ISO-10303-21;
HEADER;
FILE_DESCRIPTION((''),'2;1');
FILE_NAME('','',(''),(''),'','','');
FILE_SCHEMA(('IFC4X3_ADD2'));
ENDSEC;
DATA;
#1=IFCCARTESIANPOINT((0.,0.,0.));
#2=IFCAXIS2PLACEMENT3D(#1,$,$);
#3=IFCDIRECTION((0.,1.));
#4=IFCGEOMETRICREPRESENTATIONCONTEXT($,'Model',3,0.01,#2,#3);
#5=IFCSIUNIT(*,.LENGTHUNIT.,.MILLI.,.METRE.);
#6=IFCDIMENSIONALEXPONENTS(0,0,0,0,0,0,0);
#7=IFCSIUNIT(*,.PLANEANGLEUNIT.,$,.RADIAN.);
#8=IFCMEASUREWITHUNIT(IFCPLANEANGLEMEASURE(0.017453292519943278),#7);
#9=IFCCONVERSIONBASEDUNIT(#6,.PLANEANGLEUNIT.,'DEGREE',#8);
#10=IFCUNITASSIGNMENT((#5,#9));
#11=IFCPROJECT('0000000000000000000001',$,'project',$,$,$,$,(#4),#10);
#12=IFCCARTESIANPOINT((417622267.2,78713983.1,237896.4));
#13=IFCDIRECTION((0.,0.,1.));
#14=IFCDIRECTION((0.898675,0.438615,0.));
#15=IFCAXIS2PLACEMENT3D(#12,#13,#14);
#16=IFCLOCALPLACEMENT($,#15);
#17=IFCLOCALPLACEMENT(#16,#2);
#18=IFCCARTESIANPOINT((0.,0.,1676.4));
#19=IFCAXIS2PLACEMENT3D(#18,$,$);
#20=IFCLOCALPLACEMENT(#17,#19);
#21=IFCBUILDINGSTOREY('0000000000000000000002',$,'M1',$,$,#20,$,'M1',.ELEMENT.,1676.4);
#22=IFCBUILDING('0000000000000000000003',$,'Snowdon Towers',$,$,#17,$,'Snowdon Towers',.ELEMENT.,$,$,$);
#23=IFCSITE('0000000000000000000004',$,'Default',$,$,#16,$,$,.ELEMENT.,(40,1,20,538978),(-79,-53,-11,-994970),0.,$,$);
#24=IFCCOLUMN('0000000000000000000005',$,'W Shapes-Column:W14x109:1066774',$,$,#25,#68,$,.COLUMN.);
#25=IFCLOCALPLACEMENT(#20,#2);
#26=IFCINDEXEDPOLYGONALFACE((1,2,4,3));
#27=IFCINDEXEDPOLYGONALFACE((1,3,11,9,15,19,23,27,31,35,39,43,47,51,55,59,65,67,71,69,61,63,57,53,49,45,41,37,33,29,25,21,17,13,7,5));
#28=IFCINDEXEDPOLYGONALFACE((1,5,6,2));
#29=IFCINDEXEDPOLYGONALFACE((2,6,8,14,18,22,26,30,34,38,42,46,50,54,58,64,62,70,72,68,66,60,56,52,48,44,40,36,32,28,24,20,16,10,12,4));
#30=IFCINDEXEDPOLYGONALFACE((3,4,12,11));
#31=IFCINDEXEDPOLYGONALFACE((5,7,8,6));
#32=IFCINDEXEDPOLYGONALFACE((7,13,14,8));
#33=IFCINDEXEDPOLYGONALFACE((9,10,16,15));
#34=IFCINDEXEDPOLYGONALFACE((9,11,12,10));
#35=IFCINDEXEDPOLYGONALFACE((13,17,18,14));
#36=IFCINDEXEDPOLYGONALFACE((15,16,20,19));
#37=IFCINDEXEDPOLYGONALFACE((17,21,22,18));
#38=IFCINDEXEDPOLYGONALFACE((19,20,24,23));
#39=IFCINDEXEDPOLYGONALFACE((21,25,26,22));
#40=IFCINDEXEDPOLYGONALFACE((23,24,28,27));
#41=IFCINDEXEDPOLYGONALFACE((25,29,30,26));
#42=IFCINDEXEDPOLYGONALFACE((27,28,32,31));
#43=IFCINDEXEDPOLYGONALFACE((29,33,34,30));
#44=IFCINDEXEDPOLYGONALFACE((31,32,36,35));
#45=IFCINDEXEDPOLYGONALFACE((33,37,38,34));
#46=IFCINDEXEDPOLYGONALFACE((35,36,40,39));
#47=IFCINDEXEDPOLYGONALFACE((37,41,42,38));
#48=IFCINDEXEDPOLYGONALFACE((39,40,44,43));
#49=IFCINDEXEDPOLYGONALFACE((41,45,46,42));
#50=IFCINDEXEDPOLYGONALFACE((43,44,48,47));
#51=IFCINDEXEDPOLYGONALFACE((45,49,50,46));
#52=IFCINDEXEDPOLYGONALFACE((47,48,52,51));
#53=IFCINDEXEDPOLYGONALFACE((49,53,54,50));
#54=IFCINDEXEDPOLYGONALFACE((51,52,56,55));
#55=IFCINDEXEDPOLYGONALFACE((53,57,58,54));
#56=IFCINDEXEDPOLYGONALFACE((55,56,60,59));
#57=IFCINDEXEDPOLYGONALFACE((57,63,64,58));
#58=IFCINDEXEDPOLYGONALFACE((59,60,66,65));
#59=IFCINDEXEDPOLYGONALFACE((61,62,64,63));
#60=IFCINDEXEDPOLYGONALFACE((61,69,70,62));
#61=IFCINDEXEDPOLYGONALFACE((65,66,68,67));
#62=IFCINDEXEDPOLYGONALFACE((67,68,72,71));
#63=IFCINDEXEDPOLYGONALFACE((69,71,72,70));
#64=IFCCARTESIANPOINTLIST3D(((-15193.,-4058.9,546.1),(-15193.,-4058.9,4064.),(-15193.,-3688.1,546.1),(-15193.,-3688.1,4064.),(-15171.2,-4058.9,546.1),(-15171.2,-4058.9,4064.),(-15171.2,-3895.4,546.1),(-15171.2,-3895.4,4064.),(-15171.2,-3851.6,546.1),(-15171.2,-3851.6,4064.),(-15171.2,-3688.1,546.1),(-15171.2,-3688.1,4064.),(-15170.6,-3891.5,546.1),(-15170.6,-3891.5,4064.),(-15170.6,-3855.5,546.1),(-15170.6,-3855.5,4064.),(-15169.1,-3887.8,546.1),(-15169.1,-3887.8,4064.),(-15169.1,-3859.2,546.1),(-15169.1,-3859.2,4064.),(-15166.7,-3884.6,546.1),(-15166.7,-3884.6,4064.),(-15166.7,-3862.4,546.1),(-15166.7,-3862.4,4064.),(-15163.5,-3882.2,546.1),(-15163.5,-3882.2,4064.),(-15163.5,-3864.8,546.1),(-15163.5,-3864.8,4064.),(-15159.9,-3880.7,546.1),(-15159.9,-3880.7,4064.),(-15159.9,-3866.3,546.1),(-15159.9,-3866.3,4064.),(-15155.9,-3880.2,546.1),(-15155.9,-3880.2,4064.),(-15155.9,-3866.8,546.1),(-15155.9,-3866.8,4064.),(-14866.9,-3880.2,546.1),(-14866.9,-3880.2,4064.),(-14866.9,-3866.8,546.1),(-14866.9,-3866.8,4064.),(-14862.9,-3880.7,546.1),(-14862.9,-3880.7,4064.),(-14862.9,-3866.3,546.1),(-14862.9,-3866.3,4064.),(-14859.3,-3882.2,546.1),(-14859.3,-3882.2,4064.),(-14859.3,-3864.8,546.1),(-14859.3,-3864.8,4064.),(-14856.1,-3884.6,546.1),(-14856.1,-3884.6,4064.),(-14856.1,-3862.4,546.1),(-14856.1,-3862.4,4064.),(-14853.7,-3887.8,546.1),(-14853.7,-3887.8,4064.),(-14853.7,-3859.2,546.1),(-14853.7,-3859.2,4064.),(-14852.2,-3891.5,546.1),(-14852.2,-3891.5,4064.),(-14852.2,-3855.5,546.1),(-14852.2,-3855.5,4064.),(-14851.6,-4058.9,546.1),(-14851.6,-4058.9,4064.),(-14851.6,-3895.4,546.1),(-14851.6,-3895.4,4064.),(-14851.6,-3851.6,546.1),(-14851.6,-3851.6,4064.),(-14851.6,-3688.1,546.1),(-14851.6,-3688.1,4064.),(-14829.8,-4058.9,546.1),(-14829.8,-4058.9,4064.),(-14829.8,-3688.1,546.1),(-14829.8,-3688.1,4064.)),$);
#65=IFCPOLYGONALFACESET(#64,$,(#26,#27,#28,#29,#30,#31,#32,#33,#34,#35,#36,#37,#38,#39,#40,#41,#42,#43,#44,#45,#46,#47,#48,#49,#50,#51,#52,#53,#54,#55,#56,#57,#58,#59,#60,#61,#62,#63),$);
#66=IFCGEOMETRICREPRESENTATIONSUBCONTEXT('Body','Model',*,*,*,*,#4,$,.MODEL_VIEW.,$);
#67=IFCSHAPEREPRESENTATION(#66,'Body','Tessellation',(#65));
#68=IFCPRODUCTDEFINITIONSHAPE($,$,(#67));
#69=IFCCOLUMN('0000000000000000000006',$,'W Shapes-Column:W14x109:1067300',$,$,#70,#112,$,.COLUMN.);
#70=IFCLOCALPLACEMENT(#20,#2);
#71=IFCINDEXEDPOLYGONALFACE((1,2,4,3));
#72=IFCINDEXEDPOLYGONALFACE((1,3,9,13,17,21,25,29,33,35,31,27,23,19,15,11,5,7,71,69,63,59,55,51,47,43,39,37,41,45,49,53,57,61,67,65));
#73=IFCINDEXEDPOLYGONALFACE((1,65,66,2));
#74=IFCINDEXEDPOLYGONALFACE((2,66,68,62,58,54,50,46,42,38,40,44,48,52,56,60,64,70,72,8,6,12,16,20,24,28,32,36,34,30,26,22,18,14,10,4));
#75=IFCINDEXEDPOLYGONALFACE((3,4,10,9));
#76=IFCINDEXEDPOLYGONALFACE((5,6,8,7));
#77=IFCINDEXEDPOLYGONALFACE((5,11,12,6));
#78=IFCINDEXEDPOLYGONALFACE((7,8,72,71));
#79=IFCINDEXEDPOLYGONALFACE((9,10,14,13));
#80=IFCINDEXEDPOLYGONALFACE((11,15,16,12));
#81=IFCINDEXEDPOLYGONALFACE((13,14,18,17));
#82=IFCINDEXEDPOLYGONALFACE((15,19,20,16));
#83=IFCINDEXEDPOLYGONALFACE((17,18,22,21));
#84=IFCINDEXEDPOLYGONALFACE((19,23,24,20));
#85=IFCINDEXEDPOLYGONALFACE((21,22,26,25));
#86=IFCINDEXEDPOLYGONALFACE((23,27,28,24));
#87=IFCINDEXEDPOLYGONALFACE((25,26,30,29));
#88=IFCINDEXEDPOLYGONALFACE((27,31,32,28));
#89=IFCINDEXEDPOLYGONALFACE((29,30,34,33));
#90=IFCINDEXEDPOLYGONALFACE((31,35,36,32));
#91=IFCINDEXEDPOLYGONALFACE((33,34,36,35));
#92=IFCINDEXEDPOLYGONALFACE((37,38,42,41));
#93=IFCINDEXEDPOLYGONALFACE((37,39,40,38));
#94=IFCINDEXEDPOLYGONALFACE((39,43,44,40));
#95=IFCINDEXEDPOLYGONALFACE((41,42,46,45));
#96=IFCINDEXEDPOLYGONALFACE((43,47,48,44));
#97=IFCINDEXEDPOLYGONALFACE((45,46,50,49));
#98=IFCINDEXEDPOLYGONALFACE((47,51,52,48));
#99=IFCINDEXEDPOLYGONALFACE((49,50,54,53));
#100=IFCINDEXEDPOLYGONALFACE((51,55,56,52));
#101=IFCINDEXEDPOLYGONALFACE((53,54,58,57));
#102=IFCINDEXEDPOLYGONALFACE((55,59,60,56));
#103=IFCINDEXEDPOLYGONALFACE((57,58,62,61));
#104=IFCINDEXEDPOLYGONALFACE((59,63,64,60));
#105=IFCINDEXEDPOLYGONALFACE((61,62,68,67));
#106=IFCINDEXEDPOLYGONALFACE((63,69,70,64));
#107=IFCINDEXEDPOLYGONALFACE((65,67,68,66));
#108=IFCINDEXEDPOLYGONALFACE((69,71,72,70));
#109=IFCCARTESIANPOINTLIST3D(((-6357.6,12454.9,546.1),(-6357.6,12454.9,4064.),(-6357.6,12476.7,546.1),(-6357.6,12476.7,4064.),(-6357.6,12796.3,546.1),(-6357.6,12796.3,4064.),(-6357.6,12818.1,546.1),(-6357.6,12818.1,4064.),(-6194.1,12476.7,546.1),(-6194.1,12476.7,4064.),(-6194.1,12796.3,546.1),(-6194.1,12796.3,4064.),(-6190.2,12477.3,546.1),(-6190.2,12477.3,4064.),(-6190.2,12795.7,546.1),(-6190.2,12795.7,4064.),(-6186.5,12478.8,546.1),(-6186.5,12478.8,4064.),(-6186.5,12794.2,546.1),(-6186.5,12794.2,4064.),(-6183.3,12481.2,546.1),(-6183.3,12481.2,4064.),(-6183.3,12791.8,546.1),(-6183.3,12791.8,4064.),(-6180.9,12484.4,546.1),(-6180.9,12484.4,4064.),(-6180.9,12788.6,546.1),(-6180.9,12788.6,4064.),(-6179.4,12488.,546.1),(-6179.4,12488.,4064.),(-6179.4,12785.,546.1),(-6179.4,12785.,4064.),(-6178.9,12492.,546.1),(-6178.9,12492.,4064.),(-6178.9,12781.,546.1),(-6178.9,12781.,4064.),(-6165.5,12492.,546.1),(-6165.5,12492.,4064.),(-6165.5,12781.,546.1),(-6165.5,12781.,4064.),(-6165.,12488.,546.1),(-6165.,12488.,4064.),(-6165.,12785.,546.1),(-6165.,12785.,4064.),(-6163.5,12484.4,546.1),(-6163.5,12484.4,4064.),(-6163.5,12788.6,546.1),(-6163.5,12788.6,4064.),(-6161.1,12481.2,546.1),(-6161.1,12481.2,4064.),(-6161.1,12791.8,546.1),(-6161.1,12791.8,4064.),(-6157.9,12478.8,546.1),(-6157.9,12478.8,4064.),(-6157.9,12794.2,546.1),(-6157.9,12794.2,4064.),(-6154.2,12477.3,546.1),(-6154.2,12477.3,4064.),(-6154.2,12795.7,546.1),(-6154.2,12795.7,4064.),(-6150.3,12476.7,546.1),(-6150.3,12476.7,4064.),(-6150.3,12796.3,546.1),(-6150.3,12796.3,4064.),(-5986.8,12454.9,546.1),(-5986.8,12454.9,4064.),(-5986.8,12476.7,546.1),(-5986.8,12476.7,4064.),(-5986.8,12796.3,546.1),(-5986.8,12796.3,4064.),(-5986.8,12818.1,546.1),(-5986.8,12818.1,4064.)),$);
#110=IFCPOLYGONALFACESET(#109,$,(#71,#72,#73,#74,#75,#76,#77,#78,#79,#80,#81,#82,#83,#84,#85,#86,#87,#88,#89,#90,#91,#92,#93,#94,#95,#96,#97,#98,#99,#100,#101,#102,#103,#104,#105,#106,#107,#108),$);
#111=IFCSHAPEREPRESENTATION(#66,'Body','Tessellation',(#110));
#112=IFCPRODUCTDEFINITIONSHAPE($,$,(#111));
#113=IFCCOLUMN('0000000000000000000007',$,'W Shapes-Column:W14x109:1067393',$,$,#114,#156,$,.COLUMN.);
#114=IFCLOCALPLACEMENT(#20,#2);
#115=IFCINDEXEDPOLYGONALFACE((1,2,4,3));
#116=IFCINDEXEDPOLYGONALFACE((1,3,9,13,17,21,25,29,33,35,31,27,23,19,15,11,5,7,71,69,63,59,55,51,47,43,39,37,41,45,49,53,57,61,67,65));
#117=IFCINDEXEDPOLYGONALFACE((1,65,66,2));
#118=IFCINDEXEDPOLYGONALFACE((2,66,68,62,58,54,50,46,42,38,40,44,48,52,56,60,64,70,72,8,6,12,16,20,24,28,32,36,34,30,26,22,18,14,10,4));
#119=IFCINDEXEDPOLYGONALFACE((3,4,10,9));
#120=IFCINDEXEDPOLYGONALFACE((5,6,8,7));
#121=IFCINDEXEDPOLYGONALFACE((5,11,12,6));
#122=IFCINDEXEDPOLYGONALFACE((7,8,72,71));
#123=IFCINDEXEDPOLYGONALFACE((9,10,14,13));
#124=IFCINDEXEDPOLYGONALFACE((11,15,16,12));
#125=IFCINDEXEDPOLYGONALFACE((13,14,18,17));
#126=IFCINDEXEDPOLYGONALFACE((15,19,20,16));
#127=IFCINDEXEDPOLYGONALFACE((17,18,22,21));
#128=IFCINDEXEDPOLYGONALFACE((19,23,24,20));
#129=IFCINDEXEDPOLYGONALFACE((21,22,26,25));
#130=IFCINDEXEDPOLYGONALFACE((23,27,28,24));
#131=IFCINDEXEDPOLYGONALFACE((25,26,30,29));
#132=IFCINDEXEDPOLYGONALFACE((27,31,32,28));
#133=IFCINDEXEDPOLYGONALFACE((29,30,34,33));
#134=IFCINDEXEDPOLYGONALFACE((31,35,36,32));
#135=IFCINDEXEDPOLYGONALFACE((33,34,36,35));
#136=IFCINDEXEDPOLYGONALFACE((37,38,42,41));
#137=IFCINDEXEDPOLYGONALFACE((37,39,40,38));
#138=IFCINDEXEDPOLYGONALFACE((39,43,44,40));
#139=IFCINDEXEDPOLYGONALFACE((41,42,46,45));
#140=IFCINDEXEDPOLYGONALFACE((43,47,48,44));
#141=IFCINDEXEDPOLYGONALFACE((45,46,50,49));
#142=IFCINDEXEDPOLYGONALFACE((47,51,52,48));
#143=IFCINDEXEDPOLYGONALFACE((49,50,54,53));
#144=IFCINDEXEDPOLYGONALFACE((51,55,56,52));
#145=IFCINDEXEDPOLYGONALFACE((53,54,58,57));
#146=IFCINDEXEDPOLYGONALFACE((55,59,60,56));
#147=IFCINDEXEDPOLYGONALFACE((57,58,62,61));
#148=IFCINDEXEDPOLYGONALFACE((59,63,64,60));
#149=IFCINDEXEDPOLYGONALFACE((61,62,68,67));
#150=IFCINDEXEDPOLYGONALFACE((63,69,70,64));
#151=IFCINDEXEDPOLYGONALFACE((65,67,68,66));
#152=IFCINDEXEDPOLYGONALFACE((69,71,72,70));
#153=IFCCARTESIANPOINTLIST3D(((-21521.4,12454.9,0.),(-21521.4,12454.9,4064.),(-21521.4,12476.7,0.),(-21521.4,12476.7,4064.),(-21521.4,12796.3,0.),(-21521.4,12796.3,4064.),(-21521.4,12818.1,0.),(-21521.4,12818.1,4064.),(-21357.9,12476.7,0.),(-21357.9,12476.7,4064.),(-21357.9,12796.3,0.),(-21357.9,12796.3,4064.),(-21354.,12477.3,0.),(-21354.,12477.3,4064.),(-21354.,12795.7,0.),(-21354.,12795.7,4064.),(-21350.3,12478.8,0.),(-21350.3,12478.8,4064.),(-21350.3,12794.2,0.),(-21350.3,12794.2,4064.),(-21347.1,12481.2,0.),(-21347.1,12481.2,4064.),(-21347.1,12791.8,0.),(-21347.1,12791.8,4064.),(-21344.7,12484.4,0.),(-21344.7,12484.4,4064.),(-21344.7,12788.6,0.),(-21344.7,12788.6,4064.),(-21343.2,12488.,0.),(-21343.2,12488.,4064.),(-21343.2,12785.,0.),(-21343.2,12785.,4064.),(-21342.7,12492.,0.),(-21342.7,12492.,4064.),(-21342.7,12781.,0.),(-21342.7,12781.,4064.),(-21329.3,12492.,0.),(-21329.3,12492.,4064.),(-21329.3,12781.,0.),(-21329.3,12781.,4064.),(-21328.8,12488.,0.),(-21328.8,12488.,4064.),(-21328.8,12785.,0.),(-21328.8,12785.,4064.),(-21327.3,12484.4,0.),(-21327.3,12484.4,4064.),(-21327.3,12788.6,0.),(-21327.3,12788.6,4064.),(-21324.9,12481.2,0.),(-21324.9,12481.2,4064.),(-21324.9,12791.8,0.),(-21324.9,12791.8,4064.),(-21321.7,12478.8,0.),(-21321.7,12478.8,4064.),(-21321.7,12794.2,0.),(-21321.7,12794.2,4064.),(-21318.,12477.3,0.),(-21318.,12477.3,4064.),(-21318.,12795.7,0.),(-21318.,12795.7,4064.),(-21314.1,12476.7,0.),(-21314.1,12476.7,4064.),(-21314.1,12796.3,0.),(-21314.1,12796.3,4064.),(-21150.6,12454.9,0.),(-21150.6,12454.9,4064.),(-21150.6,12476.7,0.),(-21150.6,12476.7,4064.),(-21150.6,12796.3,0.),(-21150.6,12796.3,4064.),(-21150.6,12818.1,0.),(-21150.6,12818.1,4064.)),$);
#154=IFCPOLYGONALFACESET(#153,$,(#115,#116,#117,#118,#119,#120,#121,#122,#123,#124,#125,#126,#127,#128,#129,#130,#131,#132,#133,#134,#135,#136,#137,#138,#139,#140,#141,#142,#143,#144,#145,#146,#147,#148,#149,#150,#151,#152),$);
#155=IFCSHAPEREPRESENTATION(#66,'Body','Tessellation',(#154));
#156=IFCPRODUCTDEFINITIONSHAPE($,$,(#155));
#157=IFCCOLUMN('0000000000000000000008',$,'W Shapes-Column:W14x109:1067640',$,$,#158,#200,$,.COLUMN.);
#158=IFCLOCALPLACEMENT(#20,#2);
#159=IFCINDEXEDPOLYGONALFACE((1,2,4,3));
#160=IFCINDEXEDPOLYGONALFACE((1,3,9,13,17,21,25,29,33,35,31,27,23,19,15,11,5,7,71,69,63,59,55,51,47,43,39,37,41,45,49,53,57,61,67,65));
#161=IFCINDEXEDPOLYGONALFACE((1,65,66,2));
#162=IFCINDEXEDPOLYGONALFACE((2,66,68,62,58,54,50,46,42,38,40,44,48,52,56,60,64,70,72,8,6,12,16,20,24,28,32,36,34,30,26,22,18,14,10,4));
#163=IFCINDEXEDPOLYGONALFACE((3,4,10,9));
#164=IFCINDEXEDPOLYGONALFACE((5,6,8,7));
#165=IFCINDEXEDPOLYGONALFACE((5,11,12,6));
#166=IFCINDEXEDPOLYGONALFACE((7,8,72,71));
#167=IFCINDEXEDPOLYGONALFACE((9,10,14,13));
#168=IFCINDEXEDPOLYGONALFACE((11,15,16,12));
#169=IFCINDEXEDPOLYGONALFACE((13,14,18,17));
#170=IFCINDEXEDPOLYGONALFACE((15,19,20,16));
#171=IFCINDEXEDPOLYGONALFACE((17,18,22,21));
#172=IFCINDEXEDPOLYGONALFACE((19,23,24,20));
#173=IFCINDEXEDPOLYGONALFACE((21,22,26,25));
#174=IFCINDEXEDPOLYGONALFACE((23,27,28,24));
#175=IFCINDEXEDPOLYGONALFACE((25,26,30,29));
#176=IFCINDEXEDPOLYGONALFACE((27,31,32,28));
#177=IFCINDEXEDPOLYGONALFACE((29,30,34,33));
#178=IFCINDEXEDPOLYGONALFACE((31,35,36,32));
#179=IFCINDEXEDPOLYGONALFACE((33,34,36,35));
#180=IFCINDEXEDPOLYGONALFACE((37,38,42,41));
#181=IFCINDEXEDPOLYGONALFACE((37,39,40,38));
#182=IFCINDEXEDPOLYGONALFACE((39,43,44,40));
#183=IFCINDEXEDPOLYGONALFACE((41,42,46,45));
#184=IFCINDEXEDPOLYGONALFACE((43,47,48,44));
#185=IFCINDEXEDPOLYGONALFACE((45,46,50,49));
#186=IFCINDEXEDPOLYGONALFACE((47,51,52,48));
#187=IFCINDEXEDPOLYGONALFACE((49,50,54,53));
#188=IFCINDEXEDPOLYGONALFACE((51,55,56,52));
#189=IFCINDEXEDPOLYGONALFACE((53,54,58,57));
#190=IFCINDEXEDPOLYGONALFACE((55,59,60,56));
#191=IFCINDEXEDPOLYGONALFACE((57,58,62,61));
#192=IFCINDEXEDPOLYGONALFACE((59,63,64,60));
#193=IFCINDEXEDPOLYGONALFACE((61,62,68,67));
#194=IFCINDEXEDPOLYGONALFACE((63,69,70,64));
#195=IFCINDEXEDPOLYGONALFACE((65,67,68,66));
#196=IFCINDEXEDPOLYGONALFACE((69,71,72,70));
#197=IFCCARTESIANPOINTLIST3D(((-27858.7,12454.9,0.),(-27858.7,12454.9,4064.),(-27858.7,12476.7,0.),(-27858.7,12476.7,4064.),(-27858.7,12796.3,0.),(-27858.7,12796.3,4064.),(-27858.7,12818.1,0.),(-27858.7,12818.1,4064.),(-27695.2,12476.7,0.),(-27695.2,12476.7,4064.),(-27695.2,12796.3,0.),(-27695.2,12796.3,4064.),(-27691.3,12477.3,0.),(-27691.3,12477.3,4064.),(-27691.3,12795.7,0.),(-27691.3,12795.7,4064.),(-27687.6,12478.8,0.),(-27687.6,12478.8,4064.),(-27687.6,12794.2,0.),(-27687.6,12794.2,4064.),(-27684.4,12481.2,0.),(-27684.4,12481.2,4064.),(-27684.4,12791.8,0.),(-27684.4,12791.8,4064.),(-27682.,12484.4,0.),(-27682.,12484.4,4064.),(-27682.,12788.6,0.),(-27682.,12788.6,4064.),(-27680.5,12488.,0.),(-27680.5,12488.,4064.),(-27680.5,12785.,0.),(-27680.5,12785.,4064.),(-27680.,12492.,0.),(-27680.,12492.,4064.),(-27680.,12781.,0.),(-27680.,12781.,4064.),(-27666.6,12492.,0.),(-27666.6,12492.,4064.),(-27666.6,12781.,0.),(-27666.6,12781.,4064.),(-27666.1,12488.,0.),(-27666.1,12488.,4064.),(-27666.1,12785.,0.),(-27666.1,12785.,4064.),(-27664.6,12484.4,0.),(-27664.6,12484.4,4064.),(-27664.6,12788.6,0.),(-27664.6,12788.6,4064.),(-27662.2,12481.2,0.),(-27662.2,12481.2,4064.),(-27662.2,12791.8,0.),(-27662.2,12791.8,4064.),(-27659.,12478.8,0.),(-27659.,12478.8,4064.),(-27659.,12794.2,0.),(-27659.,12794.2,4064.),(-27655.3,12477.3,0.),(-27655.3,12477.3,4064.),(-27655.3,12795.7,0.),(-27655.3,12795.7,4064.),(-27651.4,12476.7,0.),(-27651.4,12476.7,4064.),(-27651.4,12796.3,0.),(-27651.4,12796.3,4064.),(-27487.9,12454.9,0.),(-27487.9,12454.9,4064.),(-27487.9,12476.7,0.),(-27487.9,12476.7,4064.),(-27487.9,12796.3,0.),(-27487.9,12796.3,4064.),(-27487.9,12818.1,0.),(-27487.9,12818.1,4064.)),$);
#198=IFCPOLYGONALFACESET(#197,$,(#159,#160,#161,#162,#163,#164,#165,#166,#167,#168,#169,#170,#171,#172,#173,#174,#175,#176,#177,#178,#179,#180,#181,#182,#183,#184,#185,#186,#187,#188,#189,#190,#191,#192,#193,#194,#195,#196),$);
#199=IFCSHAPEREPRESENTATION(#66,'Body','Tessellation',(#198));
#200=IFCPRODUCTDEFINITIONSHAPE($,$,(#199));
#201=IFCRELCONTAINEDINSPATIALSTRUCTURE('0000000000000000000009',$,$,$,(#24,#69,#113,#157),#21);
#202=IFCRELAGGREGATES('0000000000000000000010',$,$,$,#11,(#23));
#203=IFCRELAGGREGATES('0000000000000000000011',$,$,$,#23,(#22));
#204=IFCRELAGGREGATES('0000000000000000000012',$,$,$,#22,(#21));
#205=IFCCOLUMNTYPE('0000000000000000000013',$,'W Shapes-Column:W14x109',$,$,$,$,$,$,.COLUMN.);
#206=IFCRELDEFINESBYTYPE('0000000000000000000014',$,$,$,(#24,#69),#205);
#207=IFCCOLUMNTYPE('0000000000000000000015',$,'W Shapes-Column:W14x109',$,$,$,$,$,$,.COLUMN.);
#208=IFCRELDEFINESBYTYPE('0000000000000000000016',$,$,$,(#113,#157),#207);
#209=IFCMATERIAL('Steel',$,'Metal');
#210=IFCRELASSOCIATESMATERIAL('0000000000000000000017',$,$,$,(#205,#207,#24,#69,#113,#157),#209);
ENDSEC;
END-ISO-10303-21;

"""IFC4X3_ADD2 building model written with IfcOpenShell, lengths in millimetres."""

from ifc_helpers import new_model, entity, si_unit, converted_unit, direction, frame, frame_2d, origin, place, context, subcontext, project, spatial, i_section, extrude, source, transform, mapped, material, material_profile, profile_set, profile_usage, type_object, type_shapes, element, save


model = new_model("IFC4X3_ADD2")

# Units and contexts
model_context = context("Model", 3, precision=0.01, world=origin(), true_north=direction((0.0, 1.0)))
body_context = subcontext(model_context, "Body", "Model", "MODEL_VIEW")
ifc_project = project(units=[si_unit("LENGTHUNIT", "METRE", prefix="MILLI"), converted_unit("PLANEANGLEUNIT", "DEGREE", entity("IfcPlaneAngleMeasure", 0.017453292519943278), si_unit("PLANEANGLEUNIT", "RADIAN"), dimensions=[0, 0, 0, 0, 0, 0, 0])], contexts=[model_context])

# Site, building, storey
site_placement = place(None, frame((417622267.2, 78713983.1, 237896.4), z_axis=(0.0, 0.0, 1.0), x_axis=(0.898675, 0.438615, 0.0)))
site = spatial("IfcSite", under=ifc_project, at=site_placement, Name="Default", CompositionType="ELEMENT", RefLatitude=(40, 1, 20, 538978), RefLongitude=(-79, -53, -11, -994970), RefElevation=0.0)
building_placement = place(site_placement, origin())
building = spatial("IfcBuilding", under=site, at=building_placement, Name="Snowdon Towers", LongName="Snowdon Towers", CompositionType="ELEMENT")
storey_placement = place(building_placement, frame((0.0, 0.0, 1676.4)))
storey = spatial("IfcBuildingStorey", under=building, at=storey_placement, Name="M1", LongName="M1", CompositionType="ELEMENT", Elevation=1676.4)

# Columns
ifc_material_1 = material(Name="Steel", Category="Metal")
ifc_material_profile_1 = material_profile(ifc_material_1, i_section(OverallWidth=370.8, OverallDepth=363.2, WebThickness=13.3, FlangeThickness=21.8, FilletRadius=15.2, at=frame_2d((0.0, 0.0), x_axis=(1.0, 0.0))), Name="W14x109")
ifc_profile_set_1 = profile_set([ifc_material_profile_1], Name="W14x109")
ifc_profile_usage_1 = profile_usage(ifc_profile_set_1)
column_type_1 = type_object("IfcColumnType", Name="W Shapes-Column:W14x109", PredefinedType="COLUMN", material=ifc_profile_set_1)
shared_shape_1 = source(origin(), body_context, "Body", "SweptSolid", [
    extrude(i_section(OverallWidth=370.8, OverallDepth=363.2, WebThickness=13.3, FlangeThickness=21.8, FilletRadius=15.2, at=frame_2d((0.0, 0.0), x_axis=(1.0, 0.0))), frame((0.0, 0.0, 2222.5), z_axis=(0.0, 0.0, 1.0), x_axis=(-1.0, 0.0, 0.0)), (0.0, 0.0, 1.0), 3517.9),
])
type_shapes(column_type_1, [shared_shape_1])
for number, where, z_axis, x_axis, name in (
    (1, (-15011.4, -3873.5, -1676.4), (0.0, 0.0, 1.0), (0.0, 1.0, 0.0), "W Shapes-Column:W14x109:1066774"),
    (2, (-6172.2, 12636.5, -1676.4), (0.0, 0.0, 1.0), (-1.0, 0.0, 0.0), "W Shapes-Column:W14x109:1067300"),
):
    element("IfcColumn", number, at=place(storey_placement, frame(where, z_axis=z_axis, x_axis=x_axis)), inside=storey, type_object=column_type_1, material=ifc_profile_usage_1, Name=name, PredefinedType="COLUMN", context=body_context, shape_type="MappedRepresentation", body=[
        mapped(shared_shape_1, transform((0.0, 0.0, 0.0), scale=1.0)),
    ])
column_type_2 = type_object("IfcColumnType", Name="W Shapes-Column:W14x109", PredefinedType="COLUMN", material=ifc_profile_set_1)
shared_shape_2 = source(origin(), body_context, "Body", "SweptSolid", [
    extrude(i_section(OverallWidth=370.8, OverallDepth=363.2, WebThickness=13.3, FlangeThickness=21.8, FilletRadius=15.2, at=frame_2d((0.0, 0.0), x_axis=(1.0, 0.0))), frame((0.0, 0.0, 1676.4), z_axis=(0.0, 0.0, 1.0), x_axis=(-1.0, 0.0, 0.0)), (0.0, 0.0, 1.0), 4064.0),
])
type_shapes(column_type_2, [shared_shape_2])
for number, where, z_axis, x_axis, name in (
    (3, (-21336.0, 12636.5, -1676.4), (0.0, 0.0, 1.0), (-1.0, 0.0, 0.0), "W Shapes-Column:W14x109:1067393"),
    (4, (-27673.3, 12636.5, -1676.4), (0.0, 0.0, 1.0), (-1.0, 0.0, 0.0), "W Shapes-Column:W14x109:1067640"),
):
    element("IfcColumn", number, at=place(storey_placement, frame(where, z_axis=z_axis, x_axis=x_axis)), inside=storey, type_object=column_type_2, material=ifc_profile_usage_1, Name=name, PredefinedType="COLUMN", context=body_context, shape_type="MappedRepresentation", body=[
        mapped(shared_shape_2, transform((0.0, 0.0, 0.0), scale=1.0)),
    ])

save(model, "model.ifc")
